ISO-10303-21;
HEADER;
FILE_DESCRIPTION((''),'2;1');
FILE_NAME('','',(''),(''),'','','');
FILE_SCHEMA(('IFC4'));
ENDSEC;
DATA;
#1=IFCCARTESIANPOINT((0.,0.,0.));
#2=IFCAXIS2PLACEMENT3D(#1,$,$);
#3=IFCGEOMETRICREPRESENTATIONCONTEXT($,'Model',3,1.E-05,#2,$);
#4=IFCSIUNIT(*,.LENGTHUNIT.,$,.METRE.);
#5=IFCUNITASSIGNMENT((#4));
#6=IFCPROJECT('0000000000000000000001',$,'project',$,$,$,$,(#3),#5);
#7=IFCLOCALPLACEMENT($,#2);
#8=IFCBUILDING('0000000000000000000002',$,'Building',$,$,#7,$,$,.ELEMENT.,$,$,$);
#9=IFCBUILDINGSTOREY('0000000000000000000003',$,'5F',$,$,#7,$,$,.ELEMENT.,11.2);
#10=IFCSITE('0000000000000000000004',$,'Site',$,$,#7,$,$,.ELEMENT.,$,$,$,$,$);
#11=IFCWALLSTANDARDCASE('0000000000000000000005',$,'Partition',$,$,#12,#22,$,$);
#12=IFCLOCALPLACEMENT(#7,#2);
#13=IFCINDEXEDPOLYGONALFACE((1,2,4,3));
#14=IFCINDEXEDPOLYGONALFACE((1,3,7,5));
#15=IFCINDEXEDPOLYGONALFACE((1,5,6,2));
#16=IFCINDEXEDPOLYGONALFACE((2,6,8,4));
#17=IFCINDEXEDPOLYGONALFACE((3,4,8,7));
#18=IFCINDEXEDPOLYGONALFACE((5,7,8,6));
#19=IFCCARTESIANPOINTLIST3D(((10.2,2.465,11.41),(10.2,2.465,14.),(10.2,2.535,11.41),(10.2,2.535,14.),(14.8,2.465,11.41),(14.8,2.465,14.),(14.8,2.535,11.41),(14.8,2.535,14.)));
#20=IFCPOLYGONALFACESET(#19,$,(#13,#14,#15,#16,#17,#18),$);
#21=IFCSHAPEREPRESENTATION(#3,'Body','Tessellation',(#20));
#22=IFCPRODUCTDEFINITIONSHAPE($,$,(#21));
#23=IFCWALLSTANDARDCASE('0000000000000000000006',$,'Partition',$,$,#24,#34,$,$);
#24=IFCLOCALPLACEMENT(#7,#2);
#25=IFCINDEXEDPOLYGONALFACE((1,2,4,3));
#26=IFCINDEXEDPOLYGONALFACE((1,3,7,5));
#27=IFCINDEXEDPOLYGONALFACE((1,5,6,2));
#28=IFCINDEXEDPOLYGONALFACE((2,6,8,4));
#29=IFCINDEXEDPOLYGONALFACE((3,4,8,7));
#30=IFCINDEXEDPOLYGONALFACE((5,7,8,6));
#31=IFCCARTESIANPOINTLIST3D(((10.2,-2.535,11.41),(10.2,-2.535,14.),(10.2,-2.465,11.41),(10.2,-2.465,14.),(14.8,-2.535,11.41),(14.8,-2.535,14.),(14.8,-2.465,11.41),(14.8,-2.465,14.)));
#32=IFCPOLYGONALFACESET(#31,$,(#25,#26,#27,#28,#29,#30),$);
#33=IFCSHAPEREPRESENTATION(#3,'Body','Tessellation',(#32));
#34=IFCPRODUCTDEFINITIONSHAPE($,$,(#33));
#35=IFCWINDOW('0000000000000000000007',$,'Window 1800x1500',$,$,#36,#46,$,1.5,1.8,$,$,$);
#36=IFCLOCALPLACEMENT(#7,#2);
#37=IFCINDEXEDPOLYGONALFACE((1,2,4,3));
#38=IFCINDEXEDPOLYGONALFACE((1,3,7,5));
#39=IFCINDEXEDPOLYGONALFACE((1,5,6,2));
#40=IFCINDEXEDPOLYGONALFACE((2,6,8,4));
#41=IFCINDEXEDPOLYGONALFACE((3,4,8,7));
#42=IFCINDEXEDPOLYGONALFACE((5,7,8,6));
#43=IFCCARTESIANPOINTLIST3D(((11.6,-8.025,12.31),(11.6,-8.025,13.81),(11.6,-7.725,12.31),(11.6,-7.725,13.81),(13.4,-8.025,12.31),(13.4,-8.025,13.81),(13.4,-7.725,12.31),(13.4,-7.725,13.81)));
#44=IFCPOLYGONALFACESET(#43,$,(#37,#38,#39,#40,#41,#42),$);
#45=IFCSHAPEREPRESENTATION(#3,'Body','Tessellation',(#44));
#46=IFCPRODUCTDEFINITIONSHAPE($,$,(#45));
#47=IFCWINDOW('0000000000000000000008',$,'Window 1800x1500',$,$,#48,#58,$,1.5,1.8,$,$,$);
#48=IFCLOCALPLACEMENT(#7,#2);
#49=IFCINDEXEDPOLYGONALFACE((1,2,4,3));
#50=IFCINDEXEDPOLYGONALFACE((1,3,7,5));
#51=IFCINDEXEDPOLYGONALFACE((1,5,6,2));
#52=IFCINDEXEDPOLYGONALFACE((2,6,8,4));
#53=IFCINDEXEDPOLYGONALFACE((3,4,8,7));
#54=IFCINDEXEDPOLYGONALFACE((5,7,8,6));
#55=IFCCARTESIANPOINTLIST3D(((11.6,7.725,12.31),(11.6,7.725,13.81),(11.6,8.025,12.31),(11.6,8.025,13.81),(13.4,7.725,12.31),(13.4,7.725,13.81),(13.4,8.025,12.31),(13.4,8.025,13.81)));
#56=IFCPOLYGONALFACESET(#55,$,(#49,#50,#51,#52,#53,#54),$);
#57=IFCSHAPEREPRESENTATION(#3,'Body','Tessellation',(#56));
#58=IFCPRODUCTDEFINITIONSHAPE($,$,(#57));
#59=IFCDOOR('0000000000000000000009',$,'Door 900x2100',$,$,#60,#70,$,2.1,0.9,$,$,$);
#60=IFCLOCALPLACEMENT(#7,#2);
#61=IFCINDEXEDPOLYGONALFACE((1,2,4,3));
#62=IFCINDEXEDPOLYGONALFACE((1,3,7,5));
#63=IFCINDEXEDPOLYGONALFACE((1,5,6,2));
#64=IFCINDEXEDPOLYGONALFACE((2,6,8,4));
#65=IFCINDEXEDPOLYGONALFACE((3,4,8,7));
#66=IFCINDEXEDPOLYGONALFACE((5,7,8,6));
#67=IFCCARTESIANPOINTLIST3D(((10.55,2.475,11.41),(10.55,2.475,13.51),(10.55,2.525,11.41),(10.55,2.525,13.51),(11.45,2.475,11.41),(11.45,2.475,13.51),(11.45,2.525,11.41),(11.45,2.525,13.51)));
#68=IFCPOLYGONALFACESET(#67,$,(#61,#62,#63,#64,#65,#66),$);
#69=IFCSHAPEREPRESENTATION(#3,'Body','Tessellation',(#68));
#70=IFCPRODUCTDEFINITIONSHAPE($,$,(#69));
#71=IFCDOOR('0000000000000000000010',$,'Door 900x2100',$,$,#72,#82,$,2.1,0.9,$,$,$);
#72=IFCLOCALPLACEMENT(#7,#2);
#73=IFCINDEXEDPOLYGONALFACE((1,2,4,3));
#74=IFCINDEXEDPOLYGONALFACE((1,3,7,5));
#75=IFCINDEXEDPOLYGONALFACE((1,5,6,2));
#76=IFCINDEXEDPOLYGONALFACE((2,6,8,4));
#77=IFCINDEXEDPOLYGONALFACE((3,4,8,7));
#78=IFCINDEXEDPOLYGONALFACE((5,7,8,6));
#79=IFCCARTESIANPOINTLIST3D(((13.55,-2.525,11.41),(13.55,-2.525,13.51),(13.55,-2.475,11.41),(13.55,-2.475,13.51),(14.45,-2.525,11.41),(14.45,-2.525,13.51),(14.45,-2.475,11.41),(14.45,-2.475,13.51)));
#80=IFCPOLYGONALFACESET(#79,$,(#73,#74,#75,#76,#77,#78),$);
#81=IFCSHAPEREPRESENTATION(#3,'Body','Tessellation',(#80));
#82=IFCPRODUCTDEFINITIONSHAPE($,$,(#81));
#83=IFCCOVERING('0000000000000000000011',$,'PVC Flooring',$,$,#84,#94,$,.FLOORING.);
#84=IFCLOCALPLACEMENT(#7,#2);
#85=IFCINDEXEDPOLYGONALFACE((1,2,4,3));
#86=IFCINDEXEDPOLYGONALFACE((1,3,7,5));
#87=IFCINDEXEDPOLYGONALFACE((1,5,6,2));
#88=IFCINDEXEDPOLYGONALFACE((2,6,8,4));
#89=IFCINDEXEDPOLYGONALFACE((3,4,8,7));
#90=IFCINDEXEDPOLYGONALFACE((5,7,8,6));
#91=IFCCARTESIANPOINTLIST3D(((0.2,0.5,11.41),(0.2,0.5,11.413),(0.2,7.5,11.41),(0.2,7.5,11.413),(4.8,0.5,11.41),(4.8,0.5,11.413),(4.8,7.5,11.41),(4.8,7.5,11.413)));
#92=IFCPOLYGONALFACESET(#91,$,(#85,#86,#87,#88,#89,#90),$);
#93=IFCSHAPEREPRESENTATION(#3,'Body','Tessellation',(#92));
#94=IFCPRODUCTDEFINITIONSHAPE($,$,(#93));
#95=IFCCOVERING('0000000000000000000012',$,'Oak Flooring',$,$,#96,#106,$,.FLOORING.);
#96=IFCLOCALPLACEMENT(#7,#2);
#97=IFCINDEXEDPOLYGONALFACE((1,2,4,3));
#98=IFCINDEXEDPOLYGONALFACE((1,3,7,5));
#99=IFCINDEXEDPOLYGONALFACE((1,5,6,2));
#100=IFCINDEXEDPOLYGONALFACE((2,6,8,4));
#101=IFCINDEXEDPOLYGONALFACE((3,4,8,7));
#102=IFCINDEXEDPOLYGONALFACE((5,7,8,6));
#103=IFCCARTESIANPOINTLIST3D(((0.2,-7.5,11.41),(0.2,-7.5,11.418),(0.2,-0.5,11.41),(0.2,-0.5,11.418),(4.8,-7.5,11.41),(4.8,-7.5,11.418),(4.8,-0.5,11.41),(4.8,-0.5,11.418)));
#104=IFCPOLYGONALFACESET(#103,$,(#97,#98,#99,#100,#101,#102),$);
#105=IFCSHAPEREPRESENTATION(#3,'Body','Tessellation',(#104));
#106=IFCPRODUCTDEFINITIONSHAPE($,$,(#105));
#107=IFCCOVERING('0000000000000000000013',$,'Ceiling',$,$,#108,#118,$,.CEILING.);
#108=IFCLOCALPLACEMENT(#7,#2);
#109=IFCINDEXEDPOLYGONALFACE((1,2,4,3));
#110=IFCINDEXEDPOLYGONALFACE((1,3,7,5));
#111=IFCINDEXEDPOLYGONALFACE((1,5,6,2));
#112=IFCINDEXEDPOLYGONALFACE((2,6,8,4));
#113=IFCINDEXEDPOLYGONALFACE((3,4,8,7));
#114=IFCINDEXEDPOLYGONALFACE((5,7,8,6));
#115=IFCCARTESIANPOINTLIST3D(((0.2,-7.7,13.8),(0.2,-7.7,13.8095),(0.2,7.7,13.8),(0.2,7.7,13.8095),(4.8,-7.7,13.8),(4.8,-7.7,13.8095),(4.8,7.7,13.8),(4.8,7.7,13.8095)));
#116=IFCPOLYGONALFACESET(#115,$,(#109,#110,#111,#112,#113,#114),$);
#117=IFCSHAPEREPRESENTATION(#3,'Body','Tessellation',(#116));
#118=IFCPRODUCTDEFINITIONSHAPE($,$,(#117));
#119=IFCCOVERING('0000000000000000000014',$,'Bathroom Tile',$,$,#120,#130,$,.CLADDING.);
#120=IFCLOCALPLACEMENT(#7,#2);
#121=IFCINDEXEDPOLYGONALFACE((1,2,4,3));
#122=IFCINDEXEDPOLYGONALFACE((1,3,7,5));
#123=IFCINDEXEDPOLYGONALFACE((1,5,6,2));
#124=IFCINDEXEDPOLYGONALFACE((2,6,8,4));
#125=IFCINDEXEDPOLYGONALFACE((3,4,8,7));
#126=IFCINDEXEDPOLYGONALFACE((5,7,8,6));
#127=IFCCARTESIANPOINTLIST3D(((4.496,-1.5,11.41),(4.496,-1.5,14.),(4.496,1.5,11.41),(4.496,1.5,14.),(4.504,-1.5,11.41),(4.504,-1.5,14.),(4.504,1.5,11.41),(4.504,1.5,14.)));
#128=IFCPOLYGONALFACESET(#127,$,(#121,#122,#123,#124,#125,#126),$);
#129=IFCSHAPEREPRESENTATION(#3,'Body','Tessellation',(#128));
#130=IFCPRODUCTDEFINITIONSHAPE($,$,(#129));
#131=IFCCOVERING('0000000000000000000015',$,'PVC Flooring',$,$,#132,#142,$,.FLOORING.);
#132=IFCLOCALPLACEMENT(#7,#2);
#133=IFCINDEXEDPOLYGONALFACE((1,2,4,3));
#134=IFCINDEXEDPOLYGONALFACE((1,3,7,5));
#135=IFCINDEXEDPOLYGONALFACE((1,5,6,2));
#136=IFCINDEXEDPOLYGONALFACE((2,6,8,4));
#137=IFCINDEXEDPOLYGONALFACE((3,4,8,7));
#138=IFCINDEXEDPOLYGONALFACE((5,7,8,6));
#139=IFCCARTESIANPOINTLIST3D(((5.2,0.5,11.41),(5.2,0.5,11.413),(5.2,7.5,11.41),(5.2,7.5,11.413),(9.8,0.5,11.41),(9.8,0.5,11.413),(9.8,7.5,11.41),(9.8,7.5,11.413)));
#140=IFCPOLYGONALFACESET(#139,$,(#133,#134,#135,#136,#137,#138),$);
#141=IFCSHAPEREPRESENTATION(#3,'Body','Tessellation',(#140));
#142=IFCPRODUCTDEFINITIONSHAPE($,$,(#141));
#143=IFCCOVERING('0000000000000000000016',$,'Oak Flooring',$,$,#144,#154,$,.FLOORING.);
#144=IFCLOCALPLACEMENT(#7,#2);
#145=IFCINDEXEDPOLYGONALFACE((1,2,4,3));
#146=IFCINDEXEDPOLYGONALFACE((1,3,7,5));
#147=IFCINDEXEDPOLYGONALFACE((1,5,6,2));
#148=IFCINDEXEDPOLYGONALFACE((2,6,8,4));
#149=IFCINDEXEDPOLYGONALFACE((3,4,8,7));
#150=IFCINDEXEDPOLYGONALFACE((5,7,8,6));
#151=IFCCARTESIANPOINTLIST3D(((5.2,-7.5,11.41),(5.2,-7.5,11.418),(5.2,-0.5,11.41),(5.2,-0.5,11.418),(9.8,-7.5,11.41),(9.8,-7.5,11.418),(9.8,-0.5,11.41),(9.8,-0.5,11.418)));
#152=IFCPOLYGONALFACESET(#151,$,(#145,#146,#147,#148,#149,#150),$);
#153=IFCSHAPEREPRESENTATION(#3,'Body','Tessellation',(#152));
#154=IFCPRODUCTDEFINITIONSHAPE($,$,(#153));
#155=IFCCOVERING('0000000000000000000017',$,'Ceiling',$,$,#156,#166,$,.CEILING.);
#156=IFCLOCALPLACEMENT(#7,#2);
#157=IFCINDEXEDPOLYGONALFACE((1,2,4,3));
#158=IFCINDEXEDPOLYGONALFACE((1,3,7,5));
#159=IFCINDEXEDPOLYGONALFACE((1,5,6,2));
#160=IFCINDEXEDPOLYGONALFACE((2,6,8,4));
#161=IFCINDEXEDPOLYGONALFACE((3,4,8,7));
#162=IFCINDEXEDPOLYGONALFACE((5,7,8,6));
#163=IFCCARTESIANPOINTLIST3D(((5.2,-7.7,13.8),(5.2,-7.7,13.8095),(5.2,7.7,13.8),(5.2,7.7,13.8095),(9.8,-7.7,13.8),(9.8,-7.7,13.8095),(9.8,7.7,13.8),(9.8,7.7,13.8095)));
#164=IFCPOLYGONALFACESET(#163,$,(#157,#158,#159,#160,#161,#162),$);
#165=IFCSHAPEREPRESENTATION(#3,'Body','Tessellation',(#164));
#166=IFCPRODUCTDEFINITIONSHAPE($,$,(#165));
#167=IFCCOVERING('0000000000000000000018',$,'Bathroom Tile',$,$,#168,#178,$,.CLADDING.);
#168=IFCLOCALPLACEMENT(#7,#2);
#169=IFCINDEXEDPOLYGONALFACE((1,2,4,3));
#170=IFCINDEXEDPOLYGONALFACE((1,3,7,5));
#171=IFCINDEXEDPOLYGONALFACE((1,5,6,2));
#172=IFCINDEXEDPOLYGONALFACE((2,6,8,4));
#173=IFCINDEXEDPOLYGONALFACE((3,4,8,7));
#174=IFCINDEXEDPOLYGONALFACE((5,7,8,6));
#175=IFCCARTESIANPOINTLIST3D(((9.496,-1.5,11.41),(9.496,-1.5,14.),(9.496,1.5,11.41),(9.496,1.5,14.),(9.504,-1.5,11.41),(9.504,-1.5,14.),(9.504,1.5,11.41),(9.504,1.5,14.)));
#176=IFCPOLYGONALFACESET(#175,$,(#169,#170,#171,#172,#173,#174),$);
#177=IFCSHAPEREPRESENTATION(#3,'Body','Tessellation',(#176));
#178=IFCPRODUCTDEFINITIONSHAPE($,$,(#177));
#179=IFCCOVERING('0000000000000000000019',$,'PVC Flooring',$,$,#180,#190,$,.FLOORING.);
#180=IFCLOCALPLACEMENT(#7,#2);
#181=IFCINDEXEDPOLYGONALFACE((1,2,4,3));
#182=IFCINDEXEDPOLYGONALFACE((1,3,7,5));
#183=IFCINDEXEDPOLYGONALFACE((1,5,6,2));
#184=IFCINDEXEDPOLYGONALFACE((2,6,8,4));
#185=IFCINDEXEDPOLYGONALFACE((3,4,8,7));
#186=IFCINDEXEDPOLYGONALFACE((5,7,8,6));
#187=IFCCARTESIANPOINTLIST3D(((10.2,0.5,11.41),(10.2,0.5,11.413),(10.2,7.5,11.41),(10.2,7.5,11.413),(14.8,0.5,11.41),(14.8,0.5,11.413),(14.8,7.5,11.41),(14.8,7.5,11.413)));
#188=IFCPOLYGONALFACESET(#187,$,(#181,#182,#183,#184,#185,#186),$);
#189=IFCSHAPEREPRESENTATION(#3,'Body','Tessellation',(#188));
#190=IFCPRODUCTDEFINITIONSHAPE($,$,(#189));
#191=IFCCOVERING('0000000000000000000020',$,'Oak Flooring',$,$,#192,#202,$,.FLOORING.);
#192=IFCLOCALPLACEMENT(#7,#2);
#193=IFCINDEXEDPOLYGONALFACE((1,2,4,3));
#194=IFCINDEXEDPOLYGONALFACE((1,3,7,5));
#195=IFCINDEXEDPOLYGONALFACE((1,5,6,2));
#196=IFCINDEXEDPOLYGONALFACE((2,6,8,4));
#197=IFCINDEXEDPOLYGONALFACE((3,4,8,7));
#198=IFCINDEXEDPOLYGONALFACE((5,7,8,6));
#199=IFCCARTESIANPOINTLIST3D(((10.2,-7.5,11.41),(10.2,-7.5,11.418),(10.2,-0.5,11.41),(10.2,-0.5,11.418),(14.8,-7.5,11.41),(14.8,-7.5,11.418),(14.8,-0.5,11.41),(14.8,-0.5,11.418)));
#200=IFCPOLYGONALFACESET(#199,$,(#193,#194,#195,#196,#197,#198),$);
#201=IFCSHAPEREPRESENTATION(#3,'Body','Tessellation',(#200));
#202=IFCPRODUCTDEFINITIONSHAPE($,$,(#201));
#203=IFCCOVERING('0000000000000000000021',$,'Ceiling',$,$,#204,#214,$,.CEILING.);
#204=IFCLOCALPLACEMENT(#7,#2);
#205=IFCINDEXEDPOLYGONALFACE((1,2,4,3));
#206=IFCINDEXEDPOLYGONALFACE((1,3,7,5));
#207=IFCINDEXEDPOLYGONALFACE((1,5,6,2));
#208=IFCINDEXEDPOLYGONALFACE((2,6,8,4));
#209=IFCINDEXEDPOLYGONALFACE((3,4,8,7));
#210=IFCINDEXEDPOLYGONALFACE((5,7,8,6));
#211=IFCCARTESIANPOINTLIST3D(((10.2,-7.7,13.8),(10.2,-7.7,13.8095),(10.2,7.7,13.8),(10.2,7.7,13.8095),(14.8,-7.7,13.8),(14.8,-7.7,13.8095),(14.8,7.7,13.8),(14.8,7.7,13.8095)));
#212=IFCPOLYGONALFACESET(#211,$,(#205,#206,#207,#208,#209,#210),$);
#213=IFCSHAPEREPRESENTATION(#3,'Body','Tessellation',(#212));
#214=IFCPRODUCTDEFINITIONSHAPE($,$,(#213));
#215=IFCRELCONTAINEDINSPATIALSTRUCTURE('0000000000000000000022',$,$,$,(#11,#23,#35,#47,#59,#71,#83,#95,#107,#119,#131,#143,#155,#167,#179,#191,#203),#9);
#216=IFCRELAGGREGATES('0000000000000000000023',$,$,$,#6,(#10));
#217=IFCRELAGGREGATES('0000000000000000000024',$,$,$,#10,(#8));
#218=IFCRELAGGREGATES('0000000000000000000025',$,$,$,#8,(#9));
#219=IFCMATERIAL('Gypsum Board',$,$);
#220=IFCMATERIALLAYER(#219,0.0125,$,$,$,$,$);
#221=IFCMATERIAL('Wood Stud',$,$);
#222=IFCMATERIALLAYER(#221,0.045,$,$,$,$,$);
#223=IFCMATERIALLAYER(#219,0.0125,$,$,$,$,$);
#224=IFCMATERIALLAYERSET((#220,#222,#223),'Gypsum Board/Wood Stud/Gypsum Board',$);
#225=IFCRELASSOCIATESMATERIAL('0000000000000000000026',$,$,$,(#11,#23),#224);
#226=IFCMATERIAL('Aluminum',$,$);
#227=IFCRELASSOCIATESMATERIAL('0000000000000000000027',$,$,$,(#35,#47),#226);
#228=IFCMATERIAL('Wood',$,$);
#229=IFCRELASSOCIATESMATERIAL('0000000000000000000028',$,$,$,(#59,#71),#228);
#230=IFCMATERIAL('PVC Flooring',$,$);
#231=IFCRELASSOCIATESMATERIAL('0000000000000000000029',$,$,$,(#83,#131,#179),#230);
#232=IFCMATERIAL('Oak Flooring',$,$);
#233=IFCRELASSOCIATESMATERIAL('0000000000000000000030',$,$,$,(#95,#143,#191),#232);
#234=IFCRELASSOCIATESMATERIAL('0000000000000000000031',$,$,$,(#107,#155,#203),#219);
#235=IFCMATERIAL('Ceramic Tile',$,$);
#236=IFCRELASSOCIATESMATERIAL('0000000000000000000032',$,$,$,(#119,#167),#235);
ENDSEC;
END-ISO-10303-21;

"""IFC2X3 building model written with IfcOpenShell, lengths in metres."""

from ifc_helpers import new_model, si_unit, frame, origin, origin_2d, place, context, project, spatial, rectangle, extrude, material, layer, layer_set, layer_usage, element, save


model = new_model("IFC2X3")

# Units and contexts
model_context = context("Model", 3, precision=1e-05, world=origin())
ifc_project = project(units=[si_unit("LENGTHUNIT", "METRE")], contexts=[model_context])

# Site, building, storey
placement = place(None, origin())
site = spatial("IfcSite", under=ifc_project, at=placement, Name="Site", CompositionType="ELEMENT")
building = spatial("IfcBuilding", under=site, at=placement, Name="Building", CompositionType="ELEMENT")
storey = spatial("IfcBuildingStorey", under=building, at=placement, Name="5F", CompositionType="ELEMENT", Elevation=11.2)

# Shared definitions
ifc_material_1 = material(Name="Gypsum Board")
ifc_layer_1 = layer(ifc_material_1, 0.0125)
ifc_material_2 = material(Name="Wood Stud")
ifc_layer_2 = layer(ifc_material_2, 0.045)
ifc_layer_3 = layer(ifc_material_1, 0.0125)
ifc_layer_set_1 = layer_set([ifc_layer_1, ifc_layer_2, ifc_layer_3], Name="Gypsum Board/Wood Stud/Gypsum Board")
ifc_layer_usage_1 = layer_usage(ifc_layer_set_1, "AXIS2", "POSITIVE", 0.0)

# Shared definitions
ifc_material_3 = material(Name="Aluminum")

# Shared definitions
ifc_material_4 = material(Name="Wood")

# Walls
for number, where, name in (
    (1, (12.5, 2.5, 11.41), "Partition"),
    (2, (12.5, -2.5, 11.41), "Partition"),
):
    element("IfcWallStandardCase", number, at=place(None, frame(where)), inside=storey, material=ifc_layer_usage_1, Name=name, context=model_context, shape_type="SweptSolid", body=[
        extrude(rectangle(XDim=4.6, YDim=0.07, at=origin_2d()), origin(), (0.0, 0.0, 1.0), 2.59),
    ])

# Windows
for number, where, name in (
    (3, (12.5, -7.875, 12.31), "Window 1800x1500"),
    (4, (12.5, 7.875, 12.31), "Window 1800x1500"),
):
    element("IfcWindow", number, at=place(None, frame(where)), inside=storey, material=ifc_material_3, Name=name, OverallHeight=1.5, OverallWidth=1.8, context=model_context, shape_type="SweptSolid", body=[
        extrude(rectangle(XDim=1.8, YDim=0.3, at=origin_2d()), origin(), (0.0, 0.0, 1.0), 1.5),
    ])

# Doors
for number, where, name in (
    (5, (11.0, 2.5, 11.41), "Door 900x2100"),
    (6, (14.0, -2.5, 11.41), "Door 900x2100"),
):
    element("IfcDoor", number, at=place(None, frame(where)), inside=storey, material=ifc_material_4, Name=name, OverallHeight=2.1, OverallWidth=0.9, context=model_context, shape_type="SweptSolid", body=[
        extrude(rectangle(XDim=0.9, YDim=0.05, at=origin_2d()), origin(), (0.0, 0.0, 1.0), 2.1),
    ])

# Coverings
ifc_material_5 = material(Name="PVC Flooring")
covering_1_placement = place(None, frame((2.5, 4.0, 11.41)))
element("IfcCovering", 7, at=covering_1_placement, inside=storey, material=ifc_material_5, Name="PVC Flooring", PredefinedType="FLOORING", context=model_context, shape_type="SweptSolid", body=[
    extrude(rectangle(XDim=4.6, YDim=7.0, at=origin_2d()), origin(), (0.0, 0.0, 1.0), 0.003),
])
ifc_material_6 = material(Name="Oak Flooring")
covering_2_placement = place(None, frame((2.5, -4.0, 11.41)))
element("IfcCovering", 8, at=covering_2_placement, inside=storey, material=ifc_material_6, Name="Oak Flooring", PredefinedType="FLOORING", context=model_context, shape_type="SweptSolid", body=[
    extrude(rectangle(XDim=4.6, YDim=7.0, at=origin_2d()), origin(), (0.0, 0.0, 1.0), 0.008),
])
covering_3_placement = place(None, frame((2.5, 0.0, 13.8)))
element("IfcCovering", 9, at=covering_3_placement, inside=storey, material=ifc_material_1, Name="Ceiling", PredefinedType="CEILING", context=model_context, shape_type="SweptSolid", body=[
    extrude(rectangle(XDim=4.6, YDim=15.4, at=origin_2d()), origin(), (0.0, 0.0, 1.0), 0.0095),
])
ifc_material_7 = material(Name="Ceramic Tile")
covering_4_placement = place(None, frame((4.5, 0.0, 11.41)))
element("IfcCovering", 10, at=covering_4_placement, inside=storey, material=ifc_material_7, Name="Bathroom Tile", PredefinedType="CLADDING", context=model_context, shape_type="SweptSolid", body=[
    extrude(rectangle(XDim=0.008, YDim=3.0, at=origin_2d()), origin(), (0.0, 0.0, 1.0), 2.59),
])
covering_5_placement = place(None, frame((7.5, 4.0, 11.41)))
element("IfcCovering", 11, at=covering_5_placement, inside=storey, material=ifc_material_5, Name="PVC Flooring", PredefinedType="FLOORING", context=model_context, shape_type="SweptSolid", body=[
    extrude(rectangle(XDim=4.6, YDim=7.0, at=origin_2d()), origin(), (0.0, 0.0, 1.0), 0.003),
])
covering_6_placement = place(None, frame((7.5, -4.0, 11.41)))
element("IfcCovering", 12, at=covering_6_placement, inside=storey, material=ifc_material_6, Name="Oak Flooring", PredefinedType="FLOORING", context=model_context, shape_type="SweptSolid", body=[
    extrude(rectangle(XDim=4.6, YDim=7.0, at=origin_2d()), origin(), (0.0, 0.0, 1.0), 0.008),
])
covering_7_placement = place(None, frame((7.5, 0.0, 13.8)))
element("IfcCovering", 13, at=covering_7_placement, inside=storey, material=ifc_material_1, Name="Ceiling", PredefinedType="CEILING", context=model_context, shape_type="SweptSolid", body=[
    extrude(rectangle(XDim=4.6, YDim=15.4, at=origin_2d()), origin(), (0.0, 0.0, 1.0), 0.0095),
])
covering_8_placement = place(None, frame((9.5, 0.0, 11.41)))
element("IfcCovering", 14, at=covering_8_placement, inside=storey, material=ifc_material_7, Name="Bathroom Tile", PredefinedType="CLADDING", context=model_context, shape_type="SweptSolid", body=[
    extrude(rectangle(XDim=0.008, YDim=3.0, at=origin_2d()), origin(), (0.0, 0.0, 1.0), 2.59),
])
covering_9_placement = place(None, frame((12.5, 4.0, 11.41)))
element("IfcCovering", 15, at=covering_9_placement, inside=storey, material=ifc_material_5, Name="PVC Flooring", PredefinedType="FLOORING", context=model_context, shape_type="SweptSolid", body=[
    extrude(rectangle(XDim=4.6, YDim=7.0, at=origin_2d()), origin(), (0.0, 0.0, 1.0), 0.003),
])
covering_10_placement = place(None, frame((12.5, -4.0, 11.41)))
element("IfcCovering", 16, at=covering_10_placement, inside=storey, material=ifc_material_6, Name="Oak Flooring", PredefinedType="FLOORING", context=model_context, shape_type="SweptSolid", body=[
    extrude(rectangle(XDim=4.6, YDim=7.0, at=origin_2d()), origin(), (0.0, 0.0, 1.0), 0.008),
])
covering_11_placement = place(None, frame((12.5, 0.0, 13.8)))
element("IfcCovering", 17, at=covering_11_placement, inside=storey, material=ifc_material_1, Name="Ceiling", PredefinedType="CEILING", context=model_context, shape_type="SweptSolid", body=[
    extrude(rectangle(XDim=4.6, YDim=15.4, at=origin_2d()), origin(), (0.0, 0.0, 1.0), 0.0095),
])

save(model, "model.ifc")
